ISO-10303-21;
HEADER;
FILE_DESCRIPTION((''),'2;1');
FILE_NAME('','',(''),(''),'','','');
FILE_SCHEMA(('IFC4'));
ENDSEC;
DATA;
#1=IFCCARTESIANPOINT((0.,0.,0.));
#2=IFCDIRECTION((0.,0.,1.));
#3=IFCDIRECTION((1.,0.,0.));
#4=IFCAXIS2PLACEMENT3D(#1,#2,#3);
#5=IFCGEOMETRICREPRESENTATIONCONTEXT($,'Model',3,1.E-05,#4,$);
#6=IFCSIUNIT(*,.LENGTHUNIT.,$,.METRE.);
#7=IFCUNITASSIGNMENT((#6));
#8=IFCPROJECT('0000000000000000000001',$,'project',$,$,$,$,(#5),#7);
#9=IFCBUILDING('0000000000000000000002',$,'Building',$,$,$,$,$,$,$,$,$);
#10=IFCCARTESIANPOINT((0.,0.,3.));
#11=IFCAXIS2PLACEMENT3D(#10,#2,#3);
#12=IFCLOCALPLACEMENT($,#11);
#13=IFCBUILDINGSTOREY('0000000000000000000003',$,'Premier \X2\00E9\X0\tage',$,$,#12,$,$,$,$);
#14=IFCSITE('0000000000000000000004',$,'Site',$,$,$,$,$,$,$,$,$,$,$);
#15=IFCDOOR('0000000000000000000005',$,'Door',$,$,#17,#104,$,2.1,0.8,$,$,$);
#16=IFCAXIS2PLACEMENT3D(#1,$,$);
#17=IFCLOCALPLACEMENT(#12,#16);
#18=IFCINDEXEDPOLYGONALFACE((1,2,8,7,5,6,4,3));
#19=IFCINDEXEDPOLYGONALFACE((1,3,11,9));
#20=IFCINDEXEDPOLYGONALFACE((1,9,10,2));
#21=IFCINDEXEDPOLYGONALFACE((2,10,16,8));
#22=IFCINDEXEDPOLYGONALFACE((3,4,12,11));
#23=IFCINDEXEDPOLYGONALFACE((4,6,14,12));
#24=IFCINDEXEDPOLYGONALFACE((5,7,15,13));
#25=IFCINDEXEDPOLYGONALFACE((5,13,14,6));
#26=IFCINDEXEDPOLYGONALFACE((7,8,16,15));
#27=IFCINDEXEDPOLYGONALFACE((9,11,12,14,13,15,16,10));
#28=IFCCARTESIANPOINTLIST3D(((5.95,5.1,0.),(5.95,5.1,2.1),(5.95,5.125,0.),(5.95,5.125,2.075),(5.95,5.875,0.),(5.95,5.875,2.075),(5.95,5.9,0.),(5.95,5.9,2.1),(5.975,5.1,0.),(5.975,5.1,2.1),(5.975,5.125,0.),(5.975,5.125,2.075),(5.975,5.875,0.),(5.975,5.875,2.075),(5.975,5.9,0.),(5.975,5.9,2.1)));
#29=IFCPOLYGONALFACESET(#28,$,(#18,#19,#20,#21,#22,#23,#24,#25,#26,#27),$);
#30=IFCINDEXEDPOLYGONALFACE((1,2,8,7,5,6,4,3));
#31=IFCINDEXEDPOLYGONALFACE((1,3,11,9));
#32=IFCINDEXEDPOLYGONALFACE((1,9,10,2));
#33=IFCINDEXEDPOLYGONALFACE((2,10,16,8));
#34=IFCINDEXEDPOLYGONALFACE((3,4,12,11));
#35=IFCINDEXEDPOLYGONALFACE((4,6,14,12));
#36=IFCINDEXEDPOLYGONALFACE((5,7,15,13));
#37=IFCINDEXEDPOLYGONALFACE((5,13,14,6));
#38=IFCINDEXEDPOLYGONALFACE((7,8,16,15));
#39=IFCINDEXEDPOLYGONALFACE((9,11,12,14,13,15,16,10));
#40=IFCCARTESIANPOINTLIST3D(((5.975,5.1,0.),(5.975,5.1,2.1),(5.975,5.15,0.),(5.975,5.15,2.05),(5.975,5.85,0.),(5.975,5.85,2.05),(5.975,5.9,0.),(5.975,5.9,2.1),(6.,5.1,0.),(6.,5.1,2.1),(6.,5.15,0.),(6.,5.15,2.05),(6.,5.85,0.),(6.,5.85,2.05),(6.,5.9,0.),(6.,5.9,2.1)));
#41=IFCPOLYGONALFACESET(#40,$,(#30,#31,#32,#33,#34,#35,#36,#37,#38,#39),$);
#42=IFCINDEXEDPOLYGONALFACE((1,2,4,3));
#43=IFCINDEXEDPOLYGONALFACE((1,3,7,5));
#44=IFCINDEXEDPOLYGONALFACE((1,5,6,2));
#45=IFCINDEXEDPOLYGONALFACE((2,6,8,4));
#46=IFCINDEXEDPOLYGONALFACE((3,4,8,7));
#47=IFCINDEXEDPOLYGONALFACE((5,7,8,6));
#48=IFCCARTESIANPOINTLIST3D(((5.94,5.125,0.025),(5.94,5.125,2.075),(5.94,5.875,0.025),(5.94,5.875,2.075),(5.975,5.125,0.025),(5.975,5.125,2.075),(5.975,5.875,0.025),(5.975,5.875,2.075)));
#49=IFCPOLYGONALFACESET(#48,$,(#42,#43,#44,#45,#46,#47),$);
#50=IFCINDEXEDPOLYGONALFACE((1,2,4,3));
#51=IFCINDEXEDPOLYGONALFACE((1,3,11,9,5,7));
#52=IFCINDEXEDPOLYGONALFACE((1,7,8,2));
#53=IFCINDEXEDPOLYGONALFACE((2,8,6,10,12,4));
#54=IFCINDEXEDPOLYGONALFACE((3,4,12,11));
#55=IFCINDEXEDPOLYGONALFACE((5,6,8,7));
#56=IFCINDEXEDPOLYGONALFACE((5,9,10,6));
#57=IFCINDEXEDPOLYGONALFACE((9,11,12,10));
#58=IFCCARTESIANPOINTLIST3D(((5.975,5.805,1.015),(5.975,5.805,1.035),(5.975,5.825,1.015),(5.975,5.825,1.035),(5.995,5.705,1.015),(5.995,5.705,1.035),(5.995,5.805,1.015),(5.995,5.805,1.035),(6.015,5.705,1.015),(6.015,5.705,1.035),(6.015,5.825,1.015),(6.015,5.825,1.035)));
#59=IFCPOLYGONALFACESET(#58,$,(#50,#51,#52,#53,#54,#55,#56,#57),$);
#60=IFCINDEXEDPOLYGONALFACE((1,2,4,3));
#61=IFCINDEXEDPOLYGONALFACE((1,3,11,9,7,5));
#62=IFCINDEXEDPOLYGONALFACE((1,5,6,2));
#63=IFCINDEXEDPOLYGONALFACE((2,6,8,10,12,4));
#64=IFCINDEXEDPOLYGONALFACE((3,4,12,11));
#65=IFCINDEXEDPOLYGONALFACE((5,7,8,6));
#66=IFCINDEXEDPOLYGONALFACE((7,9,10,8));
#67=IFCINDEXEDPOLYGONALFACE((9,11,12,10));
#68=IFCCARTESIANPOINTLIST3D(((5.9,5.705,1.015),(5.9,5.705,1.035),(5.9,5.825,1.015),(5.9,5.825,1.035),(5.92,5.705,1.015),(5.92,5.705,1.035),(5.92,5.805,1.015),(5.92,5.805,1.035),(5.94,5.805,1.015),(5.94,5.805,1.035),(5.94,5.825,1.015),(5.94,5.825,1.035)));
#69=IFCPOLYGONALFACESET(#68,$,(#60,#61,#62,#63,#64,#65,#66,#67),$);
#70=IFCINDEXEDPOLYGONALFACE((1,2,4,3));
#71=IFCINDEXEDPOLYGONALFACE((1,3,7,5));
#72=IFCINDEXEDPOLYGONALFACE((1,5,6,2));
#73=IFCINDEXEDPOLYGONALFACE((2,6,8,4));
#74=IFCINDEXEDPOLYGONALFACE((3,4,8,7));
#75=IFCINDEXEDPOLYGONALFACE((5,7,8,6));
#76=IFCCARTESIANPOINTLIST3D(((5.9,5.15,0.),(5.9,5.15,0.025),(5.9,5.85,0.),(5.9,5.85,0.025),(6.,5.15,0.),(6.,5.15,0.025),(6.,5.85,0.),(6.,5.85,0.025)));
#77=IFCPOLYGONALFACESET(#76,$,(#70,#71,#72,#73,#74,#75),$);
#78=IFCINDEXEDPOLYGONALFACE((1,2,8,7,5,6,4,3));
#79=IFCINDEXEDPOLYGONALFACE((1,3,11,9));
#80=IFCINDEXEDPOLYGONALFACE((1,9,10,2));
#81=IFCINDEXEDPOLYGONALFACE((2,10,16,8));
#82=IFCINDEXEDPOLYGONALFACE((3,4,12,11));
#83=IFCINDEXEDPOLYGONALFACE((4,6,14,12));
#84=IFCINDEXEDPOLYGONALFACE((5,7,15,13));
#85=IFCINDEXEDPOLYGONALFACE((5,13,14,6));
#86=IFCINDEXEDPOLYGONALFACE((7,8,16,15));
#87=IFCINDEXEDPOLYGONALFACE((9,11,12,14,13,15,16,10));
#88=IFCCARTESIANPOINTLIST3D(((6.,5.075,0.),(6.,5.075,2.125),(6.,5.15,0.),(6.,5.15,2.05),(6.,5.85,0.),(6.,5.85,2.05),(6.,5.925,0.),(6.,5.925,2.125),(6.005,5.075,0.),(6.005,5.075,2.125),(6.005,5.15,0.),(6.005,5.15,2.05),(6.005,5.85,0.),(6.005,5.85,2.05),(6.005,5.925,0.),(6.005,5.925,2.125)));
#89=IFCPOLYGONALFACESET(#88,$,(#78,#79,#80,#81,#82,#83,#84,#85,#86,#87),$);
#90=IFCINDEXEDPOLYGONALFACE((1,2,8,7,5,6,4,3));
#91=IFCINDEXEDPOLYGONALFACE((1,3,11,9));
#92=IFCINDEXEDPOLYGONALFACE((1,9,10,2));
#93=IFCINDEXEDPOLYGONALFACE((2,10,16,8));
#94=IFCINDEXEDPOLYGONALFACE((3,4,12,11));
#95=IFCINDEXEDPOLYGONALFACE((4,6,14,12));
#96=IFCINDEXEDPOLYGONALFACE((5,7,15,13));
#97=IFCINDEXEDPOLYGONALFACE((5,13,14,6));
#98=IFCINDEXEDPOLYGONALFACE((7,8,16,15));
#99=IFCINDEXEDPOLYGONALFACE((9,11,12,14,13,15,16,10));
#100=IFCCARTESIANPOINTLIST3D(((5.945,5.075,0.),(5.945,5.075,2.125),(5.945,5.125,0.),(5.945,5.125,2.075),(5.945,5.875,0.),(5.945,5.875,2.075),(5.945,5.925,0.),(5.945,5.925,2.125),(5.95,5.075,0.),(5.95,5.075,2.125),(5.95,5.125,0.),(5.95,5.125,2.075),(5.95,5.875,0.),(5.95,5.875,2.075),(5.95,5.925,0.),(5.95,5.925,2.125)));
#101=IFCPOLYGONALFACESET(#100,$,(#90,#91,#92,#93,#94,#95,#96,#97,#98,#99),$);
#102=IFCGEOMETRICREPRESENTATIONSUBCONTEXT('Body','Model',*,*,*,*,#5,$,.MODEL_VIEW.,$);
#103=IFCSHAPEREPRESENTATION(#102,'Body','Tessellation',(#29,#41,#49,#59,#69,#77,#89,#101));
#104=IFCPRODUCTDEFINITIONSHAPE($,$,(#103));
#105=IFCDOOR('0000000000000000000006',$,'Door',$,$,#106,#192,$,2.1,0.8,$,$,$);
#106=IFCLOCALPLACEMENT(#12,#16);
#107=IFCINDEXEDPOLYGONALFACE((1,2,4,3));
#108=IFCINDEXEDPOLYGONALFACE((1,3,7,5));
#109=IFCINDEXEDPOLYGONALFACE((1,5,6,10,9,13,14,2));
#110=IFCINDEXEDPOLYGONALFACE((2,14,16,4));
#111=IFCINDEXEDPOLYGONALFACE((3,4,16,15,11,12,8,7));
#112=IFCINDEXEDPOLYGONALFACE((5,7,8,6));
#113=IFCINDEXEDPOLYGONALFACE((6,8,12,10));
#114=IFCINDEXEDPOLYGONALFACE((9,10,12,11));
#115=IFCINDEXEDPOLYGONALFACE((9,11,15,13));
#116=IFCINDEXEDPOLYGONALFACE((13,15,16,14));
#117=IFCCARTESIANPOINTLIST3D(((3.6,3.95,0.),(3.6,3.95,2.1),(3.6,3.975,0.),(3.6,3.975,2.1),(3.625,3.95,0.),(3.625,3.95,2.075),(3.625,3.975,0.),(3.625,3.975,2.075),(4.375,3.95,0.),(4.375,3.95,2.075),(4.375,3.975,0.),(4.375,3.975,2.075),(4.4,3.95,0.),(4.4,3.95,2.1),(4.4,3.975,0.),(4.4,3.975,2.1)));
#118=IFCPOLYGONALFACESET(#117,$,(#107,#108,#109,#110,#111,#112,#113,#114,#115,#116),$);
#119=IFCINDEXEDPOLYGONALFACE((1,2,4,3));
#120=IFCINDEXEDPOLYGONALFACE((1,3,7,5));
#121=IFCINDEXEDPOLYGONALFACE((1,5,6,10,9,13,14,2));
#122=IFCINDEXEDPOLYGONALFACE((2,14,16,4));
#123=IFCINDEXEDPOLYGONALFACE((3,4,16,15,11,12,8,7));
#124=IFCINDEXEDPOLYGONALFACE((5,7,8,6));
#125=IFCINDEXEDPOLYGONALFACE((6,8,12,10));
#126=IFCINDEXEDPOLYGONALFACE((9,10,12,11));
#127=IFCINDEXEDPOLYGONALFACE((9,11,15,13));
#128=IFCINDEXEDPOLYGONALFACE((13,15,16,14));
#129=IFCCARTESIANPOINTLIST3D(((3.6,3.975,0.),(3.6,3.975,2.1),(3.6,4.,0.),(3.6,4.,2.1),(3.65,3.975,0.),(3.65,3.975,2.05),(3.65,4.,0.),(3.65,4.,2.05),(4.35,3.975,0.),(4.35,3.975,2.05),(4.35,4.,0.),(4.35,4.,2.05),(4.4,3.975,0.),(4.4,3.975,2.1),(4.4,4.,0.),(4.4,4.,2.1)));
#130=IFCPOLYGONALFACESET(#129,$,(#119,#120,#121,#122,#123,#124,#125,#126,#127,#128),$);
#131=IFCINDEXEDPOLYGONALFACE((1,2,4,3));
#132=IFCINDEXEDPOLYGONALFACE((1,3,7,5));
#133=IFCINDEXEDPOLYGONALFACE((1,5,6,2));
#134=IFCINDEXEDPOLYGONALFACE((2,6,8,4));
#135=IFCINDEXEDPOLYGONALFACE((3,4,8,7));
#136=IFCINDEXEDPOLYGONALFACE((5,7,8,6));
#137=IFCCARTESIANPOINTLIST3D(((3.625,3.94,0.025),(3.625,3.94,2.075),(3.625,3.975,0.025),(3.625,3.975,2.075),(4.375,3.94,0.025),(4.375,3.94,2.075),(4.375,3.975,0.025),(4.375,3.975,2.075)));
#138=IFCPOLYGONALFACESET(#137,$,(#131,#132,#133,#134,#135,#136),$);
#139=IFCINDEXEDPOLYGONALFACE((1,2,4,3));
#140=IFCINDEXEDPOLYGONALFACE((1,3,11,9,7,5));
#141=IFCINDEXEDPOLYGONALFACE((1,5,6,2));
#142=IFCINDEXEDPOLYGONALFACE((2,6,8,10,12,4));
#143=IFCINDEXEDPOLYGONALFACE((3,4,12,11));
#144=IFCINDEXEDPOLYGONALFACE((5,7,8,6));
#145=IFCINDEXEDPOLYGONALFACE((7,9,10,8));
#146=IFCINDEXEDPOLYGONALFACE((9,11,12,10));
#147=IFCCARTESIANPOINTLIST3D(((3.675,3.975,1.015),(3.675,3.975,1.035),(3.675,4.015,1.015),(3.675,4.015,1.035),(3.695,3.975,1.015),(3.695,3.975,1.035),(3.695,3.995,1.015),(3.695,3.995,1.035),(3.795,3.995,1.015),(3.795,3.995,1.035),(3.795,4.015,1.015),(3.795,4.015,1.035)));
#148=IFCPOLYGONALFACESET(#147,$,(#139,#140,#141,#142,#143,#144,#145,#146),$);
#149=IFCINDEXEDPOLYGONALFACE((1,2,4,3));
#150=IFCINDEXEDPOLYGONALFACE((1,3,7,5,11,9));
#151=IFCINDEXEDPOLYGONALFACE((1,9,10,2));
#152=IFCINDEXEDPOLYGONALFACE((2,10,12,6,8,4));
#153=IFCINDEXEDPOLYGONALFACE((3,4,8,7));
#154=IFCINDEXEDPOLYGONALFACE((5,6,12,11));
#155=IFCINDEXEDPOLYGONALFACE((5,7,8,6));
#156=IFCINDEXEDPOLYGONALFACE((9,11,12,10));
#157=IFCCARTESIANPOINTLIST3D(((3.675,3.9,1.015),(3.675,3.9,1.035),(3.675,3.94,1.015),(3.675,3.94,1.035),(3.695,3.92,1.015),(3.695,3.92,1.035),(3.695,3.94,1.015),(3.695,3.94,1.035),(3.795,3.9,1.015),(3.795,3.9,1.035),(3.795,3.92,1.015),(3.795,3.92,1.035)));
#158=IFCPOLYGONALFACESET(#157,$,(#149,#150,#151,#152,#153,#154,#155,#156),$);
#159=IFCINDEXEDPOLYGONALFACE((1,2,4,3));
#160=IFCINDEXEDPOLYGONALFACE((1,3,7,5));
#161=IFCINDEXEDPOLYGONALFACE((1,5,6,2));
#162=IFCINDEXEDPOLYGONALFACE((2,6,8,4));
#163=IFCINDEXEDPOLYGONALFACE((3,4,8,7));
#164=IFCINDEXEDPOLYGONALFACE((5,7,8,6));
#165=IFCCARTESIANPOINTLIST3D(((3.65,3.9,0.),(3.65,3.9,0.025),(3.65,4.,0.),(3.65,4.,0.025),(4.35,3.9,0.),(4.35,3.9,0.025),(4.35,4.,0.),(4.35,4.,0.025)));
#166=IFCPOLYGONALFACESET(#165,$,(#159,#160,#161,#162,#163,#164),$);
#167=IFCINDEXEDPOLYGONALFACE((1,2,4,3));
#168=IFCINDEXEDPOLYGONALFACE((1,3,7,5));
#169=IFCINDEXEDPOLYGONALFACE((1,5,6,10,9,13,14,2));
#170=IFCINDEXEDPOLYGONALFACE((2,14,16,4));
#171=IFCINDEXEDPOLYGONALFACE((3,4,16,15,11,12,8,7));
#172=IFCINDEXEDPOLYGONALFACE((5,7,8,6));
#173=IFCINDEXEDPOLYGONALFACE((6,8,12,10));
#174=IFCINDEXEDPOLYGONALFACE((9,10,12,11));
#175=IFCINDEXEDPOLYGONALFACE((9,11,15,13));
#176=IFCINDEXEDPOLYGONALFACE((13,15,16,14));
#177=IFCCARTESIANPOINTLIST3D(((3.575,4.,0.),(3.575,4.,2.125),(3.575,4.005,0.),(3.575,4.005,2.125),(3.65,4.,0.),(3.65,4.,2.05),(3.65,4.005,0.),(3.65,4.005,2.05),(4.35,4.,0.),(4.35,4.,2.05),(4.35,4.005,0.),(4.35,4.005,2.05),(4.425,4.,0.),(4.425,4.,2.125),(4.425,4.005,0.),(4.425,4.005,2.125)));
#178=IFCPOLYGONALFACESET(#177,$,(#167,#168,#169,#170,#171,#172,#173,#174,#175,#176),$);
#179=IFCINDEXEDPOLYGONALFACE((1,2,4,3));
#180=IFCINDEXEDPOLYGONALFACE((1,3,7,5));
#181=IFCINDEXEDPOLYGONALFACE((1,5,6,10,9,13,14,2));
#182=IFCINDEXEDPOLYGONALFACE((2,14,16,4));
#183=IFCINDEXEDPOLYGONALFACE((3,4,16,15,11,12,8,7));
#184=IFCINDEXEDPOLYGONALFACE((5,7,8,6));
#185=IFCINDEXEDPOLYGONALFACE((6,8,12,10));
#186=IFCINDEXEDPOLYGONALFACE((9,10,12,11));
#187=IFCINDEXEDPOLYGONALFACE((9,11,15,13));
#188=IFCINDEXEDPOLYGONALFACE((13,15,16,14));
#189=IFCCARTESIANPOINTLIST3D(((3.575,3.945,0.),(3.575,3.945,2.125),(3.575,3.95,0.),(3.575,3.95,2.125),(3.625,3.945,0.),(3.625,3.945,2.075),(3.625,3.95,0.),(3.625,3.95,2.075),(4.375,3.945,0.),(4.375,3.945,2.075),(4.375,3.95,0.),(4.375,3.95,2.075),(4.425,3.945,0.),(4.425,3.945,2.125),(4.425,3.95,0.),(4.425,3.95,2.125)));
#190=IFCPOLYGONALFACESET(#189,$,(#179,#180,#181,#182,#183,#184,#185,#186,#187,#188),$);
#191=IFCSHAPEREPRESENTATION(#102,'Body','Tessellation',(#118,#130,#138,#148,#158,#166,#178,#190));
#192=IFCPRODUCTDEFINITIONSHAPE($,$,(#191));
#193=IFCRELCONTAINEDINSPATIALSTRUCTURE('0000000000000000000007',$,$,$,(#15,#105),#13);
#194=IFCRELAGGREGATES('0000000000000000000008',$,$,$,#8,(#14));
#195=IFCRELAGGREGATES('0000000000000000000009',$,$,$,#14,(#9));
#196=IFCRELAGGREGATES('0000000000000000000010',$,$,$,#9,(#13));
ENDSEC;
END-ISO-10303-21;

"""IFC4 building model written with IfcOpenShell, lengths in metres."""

from ifc_helpers import new_model, si_unit, frame, origin_with_axes, place, context, subcontext, project, spatial, line, indexed_curve, outline, extrude, element, save


model = new_model("IFC4")

# Units and contexts
model_context = context("Model", 3, precision=1e-05, world=origin_with_axes())
body_context = subcontext(model_context, "Body", "Model", "MODEL_VIEW")
ifc_project = project(units=[si_unit("LENGTHUNIT", "METRE")], contexts=[model_context])

# Site, building, storey
site = spatial("IfcSite", under=ifc_project, Name="Site")
building = spatial("IfcBuilding", under=site, Name="Building")
storey_placement = place(None, frame((0.0, 0.0, 3.0), z_axis=(0.0, 0.0, 1.0), x_axis=(1.0, 0.0, 0.0)))
storey = spatial("IfcBuildingStorey", under=building, at=storey_placement, Name="Premier étage")

# Doors
door_1_placement = place(storey_placement, frame((6.0, 5.1, 0.0), z_axis=(0.0, 0.0, 1.0), x_axis=(0.0, 1.0, 0.0)))
element("IfcDoor", 1, at=door_1_placement, inside=storey, Name="Door", OverallHeight=2.1, OverallWidth=0.8, context=body_context, shape_type="SweptSolid", body=[
    extrude(outline(indexed_curve([(0.0, 0.0), (0.0, 2.1), (0.8, 2.1), (0.8, 0.0), (0.775, 0.0), (0.775, 2.075), (0.025, 2.075), (0.025, 0.0)], segments=[line(1, 2, 3, 4, 5, 6, 7, 8, 1)])), frame((0.0, 0.025, 0.0), z_axis=(0.0, -1.0, 0.0), x_axis=(1.0, 0.0, 0.0)), (0.0, 0.0, -1.0), 0.025),
    extrude(outline(indexed_curve([(0.0, 0.0), (0.0, 2.1), (0.8, 2.1), (0.8, 0.0), (0.75, 0.0), (0.75, 2.05), (0.05, 2.05), (0.05, 0.0)], segments=[line(1, 2, 3, 4, 5, 6, 7, 8, 1)])), frame((0.0, 0.0, 0.0), z_axis=(0.0, -1.0, 0.0), x_axis=(1.0, 0.0, 0.0)), (0.0, 0.0, -1.0), 0.025),
    extrude(outline(indexed_curve([(0.0, 0.0), (0.75, 0.0), (0.75, 0.035), (0.0, 0.035)], segments=[line(1, 2, 3, 4, 1)])), frame((0.025, 0.025, 0.025), z_axis=(0.0, 0.0, 1.0), x_axis=(1.0, 0.0, 0.0)), (0.0, 0.0, 1.0), 2.05),
    extrude(outline(indexed_curve([(0.0, 0.0), (0.0, -0.04), (-0.12, -0.04), (-0.12, -0.02), (-0.02, -0.02), (-0.02, 0.0)], segments=[line(1, 2, 3, 4, 5, 6, 1)])), frame((0.725, 0.025, 1.015), z_axis=(0.0, 0.0, 1.0), x_axis=(1.0, 0.0, 0.0)), (0.0, 0.0, 1.0), 0.02),
    extrude(outline(indexed_curve([(0.0, 0.0), (0.0, 0.04), (-0.12, 0.04), (-0.12, 0.02), (-0.02, 0.02), (-0.02, 0.0)], segments=[line(1, 2, 3, 4, 5, 6, 1)])), frame((0.725, 0.06, 1.015), z_axis=(0.0, 0.0, 1.0), x_axis=(1.0, 0.0, 0.0)), (0.0, 0.0, 1.0), 0.02),
    extrude(outline(indexed_curve([(0.0, 0.0), (0.7, 0.0), (0.7, 0.1), (0.0, 0.1)], segments=[line(1, 2, 3, 4, 1)])), frame((0.05, 0.0, 0.0), z_axis=(0.0, 0.0, 1.0), x_axis=(1.0, 0.0, 0.0)), (0.0, 0.0, 1.0), 0.025),
    extrude(outline(indexed_curve([(0.0, 0.0), (0.0, 2.125), (0.85, 2.125), (0.85, 0.0), (0.775, 0.0), (0.775, 2.05), (0.075, 2.05), (0.075, 0.0)], segments=[line(1, 2, 3, 4, 5, 6, 7, 8, 1)])), frame((-0.025, -0.005, 0.0), z_axis=(0.0, -1.0, 0.0), x_axis=(1.0, 0.0, 0.0)), (0.0, 0.0, -1.0), 0.005),
    extrude(outline(indexed_curve([(0.0, 0.0), (0.0, 2.125), (0.85, 2.125), (0.85, 0.0), (0.8, 0.0), (0.8, 2.075), (0.05, 2.075), (0.05, 0.0)], segments=[line(1, 2, 3, 4, 5, 6, 7, 8, 1)])), frame((-0.025, 0.05, 0.0), z_axis=(0.0, -1.0, 0.0), x_axis=(1.0, 0.0, 0.0)), (0.0, 0.0, -1.0), 0.005),
])
door_2_placement = place(storey_placement, frame((4.4, 4.0, 0.0), z_axis=(0.0, 0.0, 1.0), x_axis=(-1.0, 0.0, 0.0)))
element("IfcDoor", 2, at=door_2_placement, inside=storey, Name="Door", OverallHeight=2.1, OverallWidth=0.8, context=body_context, shape_type="SweptSolid", body=[
    extrude(outline(indexed_curve([(0.0, 0.0), (0.0, 2.1), (0.8, 2.1), (0.8, 0.0), (0.775, 0.0), (0.775, 2.075), (0.025, 2.075), (0.025, 0.0)], segments=[line(1, 2, 3, 4, 5, 6, 7, 8, 1)])), frame((0.0, 0.025, 0.0), z_axis=(0.0, -1.0, 0.0), x_axis=(1.0, 0.0, 0.0)), (0.0, 0.0, -1.0), 0.025),
    extrude(outline(indexed_curve([(0.0, 0.0), (0.0, 2.1), (0.8, 2.1), (0.8, 0.0), (0.75, 0.0), (0.75, 2.05), (0.05, 2.05), (0.05, 0.0)], segments=[line(1, 2, 3, 4, 5, 6, 7, 8, 1)])), frame((0.0, 0.0, 0.0), z_axis=(0.0, -1.0, 0.0), x_axis=(1.0, 0.0, 0.0)), (0.0, 0.0, -1.0), 0.025),
    extrude(outline(indexed_curve([(0.0, 0.0), (0.75, 0.0), (0.75, 0.035), (0.0, 0.035)], segments=[line(1, 2, 3, 4, 1)])), frame((0.025, 0.025, 0.025), z_axis=(0.0, 0.0, 1.0), x_axis=(1.0, 0.0, 0.0)), (0.0, 0.0, 1.0), 2.05),
    extrude(outline(indexed_curve([(0.0, 0.0), (0.0, -0.04), (-0.12, -0.04), (-0.12, -0.02), (-0.02, -0.02), (-0.02, 0.0)], segments=[line(1, 2, 3, 4, 5, 6, 1)])), frame((0.725, 0.025, 1.015), z_axis=(0.0, 0.0, 1.0), x_axis=(1.0, 0.0, 0.0)), (0.0, 0.0, 1.0), 0.02),
    extrude(outline(indexed_curve([(0.0, 0.0), (0.0, 0.04), (-0.12, 0.04), (-0.12, 0.02), (-0.02, 0.02), (-0.02, 0.0)], segments=[line(1, 2, 3, 4, 5, 6, 1)])), frame((0.725, 0.06, 1.015), z_axis=(0.0, 0.0, 1.0), x_axis=(1.0, 0.0, 0.0)), (0.0, 0.0, 1.0), 0.02),
    extrude(outline(indexed_curve([(0.0, 0.0), (0.7, 0.0), (0.7, 0.1), (0.0, 0.1)], segments=[line(1, 2, 3, 4, 1)])), frame((0.05, 0.0, 0.0), z_axis=(0.0, 0.0, 1.0), x_axis=(1.0, 0.0, 0.0)), (0.0, 0.0, 1.0), 0.025),
    extrude(outline(indexed_curve([(0.0, 0.0), (0.0, 2.125), (0.85, 2.125), (0.85, 0.0), (0.775, 0.0), (0.775, 2.05), (0.075, 2.05), (0.075, 0.0)], segments=[line(1, 2, 3, 4, 5, 6, 7, 8, 1)])), frame((-0.025, -0.005, 0.0), z_axis=(0.0, -1.0, 0.0), x_axis=(1.0, 0.0, 0.0)), (0.0, 0.0, -1.0), 0.005),
    extrude(outline(indexed_curve([(0.0, 0.0), (0.0, 2.125), (0.85, 2.125), (0.85, 0.0), (0.8, 0.0), (0.8, 2.075), (0.05, 2.075), (0.05, 0.0)], segments=[line(1, 2, 3, 4, 5, 6, 7, 8, 1)])), frame((-0.025, 0.05, 0.0), z_axis=(0.0, -1.0, 0.0), x_axis=(1.0, 0.0, 0.0)), (0.0, 0.0, -1.0), 0.005),
])

save(model, "model.ifc")
